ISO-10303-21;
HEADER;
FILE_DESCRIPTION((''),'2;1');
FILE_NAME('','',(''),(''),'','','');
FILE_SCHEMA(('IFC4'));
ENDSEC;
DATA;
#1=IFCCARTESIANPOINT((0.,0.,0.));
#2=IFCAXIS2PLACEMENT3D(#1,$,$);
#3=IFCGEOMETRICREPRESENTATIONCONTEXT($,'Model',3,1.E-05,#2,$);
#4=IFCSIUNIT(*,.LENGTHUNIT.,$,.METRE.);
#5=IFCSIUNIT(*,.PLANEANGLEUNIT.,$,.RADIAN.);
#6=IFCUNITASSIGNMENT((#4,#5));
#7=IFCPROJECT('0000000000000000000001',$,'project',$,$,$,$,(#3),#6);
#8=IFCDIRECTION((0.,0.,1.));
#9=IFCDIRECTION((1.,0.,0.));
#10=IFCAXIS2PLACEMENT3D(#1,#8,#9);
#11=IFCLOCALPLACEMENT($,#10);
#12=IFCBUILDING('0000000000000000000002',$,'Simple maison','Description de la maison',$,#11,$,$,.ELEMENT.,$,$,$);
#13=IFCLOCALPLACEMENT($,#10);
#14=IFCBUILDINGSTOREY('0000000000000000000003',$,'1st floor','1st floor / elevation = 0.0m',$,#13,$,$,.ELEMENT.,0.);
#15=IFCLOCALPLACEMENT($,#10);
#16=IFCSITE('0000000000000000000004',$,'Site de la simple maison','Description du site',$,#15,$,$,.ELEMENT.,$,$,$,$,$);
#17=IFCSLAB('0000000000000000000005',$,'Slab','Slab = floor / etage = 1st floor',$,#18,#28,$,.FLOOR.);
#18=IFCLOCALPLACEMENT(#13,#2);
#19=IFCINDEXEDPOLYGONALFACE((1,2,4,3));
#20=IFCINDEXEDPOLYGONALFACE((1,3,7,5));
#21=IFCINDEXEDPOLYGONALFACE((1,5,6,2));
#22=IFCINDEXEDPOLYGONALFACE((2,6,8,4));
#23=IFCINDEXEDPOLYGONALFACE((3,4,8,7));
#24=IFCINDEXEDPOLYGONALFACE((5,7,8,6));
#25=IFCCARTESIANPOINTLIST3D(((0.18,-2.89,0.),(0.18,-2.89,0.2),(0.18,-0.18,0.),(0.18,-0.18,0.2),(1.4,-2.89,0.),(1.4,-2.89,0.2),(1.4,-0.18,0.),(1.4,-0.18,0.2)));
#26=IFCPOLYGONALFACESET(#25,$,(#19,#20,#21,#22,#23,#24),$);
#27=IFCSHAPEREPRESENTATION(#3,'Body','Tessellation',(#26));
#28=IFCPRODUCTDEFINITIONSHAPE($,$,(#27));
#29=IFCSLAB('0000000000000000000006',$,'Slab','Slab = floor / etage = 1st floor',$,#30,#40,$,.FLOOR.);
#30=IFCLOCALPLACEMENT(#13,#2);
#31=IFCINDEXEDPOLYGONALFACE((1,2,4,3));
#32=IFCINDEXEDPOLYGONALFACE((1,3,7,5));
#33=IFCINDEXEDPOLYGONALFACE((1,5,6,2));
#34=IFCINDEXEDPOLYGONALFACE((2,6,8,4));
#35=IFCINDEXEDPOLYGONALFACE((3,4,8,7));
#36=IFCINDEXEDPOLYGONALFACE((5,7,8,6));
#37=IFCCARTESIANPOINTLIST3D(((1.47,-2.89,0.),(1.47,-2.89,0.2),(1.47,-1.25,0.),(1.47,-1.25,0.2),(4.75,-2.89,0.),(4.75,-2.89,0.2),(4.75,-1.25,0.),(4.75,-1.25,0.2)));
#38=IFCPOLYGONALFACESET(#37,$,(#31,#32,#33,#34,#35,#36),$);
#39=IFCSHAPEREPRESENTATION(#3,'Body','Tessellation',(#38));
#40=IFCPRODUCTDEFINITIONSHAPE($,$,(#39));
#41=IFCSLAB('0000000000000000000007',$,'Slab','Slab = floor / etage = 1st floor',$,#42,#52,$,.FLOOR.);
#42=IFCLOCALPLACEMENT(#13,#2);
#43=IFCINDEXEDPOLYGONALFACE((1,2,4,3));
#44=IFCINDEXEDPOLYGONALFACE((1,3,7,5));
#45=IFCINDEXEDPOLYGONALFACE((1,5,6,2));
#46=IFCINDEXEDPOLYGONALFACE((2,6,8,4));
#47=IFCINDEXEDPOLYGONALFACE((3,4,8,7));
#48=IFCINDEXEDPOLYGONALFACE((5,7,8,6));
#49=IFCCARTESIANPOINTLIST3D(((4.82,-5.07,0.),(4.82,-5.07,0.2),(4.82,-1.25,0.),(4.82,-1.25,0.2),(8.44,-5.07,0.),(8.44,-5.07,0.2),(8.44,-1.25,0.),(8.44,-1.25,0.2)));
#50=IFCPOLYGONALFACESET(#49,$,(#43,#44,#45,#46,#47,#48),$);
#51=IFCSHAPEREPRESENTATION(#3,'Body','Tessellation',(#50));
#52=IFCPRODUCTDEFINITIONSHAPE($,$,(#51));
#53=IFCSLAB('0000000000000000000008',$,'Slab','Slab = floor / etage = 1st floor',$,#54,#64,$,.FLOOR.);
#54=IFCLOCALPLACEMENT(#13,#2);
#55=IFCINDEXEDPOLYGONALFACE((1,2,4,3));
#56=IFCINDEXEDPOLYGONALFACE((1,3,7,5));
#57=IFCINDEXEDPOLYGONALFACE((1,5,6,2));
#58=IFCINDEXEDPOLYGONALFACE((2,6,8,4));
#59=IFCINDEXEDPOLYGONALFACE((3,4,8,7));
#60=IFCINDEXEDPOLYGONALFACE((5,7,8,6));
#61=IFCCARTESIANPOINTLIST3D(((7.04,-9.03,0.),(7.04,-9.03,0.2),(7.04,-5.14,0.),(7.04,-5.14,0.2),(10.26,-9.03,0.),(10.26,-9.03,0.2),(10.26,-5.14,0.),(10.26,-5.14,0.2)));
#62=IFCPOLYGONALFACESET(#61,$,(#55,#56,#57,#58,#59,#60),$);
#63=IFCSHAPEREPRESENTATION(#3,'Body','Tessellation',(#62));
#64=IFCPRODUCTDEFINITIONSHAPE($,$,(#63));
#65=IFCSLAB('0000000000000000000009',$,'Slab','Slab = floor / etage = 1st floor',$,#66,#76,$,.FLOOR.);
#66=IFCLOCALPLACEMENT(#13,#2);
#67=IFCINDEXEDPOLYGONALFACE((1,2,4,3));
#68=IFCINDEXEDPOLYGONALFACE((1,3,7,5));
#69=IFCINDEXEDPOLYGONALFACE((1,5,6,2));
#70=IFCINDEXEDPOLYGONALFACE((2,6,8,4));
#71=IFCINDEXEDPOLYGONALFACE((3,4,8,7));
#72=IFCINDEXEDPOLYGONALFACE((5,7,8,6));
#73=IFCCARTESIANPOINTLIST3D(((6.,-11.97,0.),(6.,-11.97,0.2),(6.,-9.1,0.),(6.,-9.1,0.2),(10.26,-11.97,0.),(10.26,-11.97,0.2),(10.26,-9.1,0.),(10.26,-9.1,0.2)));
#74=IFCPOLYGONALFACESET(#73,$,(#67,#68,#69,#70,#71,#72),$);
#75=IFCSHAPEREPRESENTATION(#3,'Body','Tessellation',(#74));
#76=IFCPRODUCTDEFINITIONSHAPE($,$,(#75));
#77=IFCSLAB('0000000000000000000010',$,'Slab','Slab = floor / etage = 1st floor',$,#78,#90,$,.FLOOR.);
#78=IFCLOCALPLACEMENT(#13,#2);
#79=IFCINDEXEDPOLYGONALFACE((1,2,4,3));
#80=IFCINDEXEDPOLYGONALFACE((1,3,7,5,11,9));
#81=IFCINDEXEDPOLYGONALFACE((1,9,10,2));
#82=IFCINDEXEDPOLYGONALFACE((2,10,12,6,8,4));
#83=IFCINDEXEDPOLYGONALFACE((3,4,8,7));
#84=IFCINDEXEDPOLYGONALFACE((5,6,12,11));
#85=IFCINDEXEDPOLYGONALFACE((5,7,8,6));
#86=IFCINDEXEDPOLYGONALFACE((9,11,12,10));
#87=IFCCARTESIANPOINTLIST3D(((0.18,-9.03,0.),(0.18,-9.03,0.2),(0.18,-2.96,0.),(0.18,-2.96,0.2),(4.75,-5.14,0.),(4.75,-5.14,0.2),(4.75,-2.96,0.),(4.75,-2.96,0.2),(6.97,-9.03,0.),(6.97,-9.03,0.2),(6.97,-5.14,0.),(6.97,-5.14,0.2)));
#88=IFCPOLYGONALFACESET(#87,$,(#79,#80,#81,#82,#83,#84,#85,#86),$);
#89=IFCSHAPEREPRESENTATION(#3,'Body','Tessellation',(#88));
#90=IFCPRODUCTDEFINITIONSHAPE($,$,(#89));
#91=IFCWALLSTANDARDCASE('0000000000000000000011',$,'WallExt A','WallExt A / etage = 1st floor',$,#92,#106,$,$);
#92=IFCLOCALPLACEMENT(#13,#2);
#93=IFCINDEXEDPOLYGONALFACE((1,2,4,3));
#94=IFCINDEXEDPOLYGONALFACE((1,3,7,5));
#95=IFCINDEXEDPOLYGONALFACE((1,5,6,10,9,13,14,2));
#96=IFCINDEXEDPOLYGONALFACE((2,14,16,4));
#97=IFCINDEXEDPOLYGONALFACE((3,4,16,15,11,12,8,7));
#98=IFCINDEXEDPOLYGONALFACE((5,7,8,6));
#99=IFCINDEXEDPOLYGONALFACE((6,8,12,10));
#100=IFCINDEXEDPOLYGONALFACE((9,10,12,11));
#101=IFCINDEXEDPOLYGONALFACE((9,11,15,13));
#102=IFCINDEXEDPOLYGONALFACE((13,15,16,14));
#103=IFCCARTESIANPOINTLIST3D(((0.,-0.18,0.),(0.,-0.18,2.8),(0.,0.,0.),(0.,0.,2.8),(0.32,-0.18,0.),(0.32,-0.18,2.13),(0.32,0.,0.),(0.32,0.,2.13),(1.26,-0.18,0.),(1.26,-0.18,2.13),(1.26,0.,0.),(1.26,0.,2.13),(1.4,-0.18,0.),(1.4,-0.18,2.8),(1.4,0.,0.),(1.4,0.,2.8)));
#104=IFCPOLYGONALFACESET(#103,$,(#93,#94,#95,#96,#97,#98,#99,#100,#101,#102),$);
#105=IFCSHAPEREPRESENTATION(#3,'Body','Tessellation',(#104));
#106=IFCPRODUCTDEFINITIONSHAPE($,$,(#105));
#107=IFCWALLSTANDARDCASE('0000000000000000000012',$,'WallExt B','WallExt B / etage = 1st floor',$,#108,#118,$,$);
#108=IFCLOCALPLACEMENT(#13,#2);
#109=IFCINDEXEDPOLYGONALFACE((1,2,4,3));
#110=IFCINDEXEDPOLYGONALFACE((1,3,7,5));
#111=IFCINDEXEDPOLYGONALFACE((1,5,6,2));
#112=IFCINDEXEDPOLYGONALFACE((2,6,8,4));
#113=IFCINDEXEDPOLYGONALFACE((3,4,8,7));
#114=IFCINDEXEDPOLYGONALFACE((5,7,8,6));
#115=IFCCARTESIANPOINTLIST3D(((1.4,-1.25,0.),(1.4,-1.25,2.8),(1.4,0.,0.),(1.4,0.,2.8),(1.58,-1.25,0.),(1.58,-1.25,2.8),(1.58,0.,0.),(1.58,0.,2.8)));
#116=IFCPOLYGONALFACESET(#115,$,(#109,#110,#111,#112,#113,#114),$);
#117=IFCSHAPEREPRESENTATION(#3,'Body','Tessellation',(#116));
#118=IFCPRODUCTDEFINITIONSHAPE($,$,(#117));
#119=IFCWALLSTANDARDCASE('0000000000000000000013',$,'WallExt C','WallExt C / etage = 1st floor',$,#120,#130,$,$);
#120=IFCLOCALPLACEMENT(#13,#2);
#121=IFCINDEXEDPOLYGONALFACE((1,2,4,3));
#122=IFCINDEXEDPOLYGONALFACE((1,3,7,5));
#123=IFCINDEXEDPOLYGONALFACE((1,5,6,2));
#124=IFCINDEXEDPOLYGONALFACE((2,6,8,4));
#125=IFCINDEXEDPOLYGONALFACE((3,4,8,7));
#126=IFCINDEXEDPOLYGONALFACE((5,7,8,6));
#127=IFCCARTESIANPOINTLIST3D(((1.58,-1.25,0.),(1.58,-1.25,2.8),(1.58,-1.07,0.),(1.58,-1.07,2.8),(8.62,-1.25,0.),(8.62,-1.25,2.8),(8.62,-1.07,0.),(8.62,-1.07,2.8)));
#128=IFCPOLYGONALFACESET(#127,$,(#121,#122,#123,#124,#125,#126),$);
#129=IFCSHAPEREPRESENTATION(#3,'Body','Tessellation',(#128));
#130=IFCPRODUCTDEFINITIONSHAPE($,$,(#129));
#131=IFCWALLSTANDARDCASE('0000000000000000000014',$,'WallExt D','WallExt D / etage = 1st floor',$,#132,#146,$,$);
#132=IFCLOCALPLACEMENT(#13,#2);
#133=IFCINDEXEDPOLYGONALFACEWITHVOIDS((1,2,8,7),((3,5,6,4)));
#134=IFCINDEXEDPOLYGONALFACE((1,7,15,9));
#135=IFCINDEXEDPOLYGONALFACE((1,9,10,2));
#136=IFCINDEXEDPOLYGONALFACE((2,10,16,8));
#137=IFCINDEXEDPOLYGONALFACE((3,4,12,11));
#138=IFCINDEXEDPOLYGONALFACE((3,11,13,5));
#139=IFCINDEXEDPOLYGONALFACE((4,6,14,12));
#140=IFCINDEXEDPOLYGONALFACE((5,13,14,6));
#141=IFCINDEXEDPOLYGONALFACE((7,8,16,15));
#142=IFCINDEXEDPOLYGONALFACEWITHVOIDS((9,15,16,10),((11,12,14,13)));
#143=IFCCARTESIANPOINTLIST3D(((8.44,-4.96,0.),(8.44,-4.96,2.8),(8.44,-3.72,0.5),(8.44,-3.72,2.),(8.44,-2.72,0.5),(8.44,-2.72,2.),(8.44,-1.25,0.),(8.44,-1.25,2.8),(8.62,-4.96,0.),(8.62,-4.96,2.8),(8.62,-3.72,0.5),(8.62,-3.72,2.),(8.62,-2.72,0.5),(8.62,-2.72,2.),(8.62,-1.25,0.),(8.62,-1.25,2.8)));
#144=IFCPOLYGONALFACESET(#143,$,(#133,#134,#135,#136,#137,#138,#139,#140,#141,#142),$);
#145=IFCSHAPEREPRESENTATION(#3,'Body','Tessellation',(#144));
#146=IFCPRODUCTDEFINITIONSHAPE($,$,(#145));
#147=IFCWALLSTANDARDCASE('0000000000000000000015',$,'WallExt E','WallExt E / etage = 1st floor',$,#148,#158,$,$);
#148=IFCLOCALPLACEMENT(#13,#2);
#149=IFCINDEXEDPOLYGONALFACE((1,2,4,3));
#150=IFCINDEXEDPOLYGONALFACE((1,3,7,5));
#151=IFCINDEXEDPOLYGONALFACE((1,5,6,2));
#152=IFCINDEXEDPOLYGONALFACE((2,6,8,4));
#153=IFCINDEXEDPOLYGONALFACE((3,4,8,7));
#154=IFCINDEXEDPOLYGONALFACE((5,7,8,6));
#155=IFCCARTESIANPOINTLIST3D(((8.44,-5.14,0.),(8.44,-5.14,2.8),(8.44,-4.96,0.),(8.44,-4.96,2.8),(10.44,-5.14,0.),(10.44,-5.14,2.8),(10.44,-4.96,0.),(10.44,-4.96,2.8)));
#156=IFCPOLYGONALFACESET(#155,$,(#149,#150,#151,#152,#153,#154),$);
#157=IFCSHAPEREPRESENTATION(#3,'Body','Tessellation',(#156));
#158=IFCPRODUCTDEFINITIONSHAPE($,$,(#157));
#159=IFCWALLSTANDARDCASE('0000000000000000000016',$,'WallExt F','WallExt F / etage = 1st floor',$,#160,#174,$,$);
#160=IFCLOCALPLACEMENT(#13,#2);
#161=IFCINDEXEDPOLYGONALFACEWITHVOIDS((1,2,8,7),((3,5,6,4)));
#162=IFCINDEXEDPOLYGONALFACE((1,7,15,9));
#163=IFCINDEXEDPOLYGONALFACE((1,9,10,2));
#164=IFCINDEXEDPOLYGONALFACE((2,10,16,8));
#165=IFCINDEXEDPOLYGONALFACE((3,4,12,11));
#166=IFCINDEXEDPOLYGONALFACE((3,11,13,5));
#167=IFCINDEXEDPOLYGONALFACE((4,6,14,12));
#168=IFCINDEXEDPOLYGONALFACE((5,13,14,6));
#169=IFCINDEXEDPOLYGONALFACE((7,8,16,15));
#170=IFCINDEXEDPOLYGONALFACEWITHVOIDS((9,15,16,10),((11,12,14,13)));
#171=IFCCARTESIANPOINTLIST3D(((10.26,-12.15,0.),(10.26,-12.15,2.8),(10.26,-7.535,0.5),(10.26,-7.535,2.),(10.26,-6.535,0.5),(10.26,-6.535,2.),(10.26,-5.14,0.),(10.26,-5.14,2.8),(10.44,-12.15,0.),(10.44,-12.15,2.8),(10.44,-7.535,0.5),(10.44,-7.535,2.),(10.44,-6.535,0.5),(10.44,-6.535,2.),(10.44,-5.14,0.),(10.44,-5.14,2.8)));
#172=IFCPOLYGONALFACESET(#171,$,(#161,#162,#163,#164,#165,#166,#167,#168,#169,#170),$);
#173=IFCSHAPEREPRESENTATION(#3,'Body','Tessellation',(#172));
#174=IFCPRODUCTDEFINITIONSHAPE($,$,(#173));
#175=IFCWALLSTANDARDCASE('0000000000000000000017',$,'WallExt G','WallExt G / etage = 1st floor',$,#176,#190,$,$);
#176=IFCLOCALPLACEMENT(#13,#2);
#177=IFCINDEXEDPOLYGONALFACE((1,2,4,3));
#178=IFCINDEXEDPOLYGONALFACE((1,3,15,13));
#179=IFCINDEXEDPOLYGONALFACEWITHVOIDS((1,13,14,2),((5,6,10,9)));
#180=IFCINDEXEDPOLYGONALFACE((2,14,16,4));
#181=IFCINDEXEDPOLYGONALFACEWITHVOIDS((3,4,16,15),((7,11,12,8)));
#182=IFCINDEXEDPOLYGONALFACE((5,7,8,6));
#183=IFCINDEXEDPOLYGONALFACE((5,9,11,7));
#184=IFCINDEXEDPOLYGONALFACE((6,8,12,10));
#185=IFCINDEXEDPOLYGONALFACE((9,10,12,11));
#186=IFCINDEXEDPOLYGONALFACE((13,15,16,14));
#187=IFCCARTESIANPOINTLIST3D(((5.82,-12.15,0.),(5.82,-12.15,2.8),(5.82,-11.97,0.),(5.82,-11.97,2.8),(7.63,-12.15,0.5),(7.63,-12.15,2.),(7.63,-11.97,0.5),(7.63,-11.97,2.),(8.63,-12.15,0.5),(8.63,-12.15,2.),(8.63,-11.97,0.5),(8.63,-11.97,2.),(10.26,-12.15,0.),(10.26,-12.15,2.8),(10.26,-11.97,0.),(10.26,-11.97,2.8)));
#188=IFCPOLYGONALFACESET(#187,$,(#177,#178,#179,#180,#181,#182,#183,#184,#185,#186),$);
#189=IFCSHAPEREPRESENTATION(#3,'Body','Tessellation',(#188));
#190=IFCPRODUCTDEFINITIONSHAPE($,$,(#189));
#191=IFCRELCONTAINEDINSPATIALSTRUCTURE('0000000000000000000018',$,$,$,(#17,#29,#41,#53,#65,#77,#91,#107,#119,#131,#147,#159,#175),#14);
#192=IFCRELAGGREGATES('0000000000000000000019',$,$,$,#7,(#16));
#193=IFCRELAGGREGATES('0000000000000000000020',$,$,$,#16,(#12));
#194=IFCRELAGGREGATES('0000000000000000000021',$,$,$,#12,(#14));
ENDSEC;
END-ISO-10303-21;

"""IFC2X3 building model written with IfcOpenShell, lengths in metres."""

from ifc_helpers import new_model, si_unit, frame, origin, origin_with_axes, origin_2d_with_axis, place, context, project, spatial, polyline, rectangle, outline, extrude, element, save


model = new_model("IFC2X3")

# Units and contexts
model_context = context("Model", 3, precision=1e-05, world=origin())
ifc_project = project(units=[si_unit("LENGTHUNIT", "METRE"), si_unit("PLANEANGLEUNIT", "RADIAN")], contexts=[model_context])

# Site, building, storey
site_placement = place(None, origin_with_axes())
site = spatial("IfcSite", under=ifc_project, at=site_placement, Name="Site de la simple maison", Description="Description du site", CompositionType="ELEMENT")
building_placement = place(None, origin_with_axes())
building = spatial("IfcBuilding", under=site, at=building_placement, Name="Simple maison", Description="Description de la maison", CompositionType="ELEMENT")
storey_placement = place(None, origin_with_axes())
storey = spatial("IfcBuildingStorey", under=building, at=storey_placement, Name="1st floor", Description="1st floor / elevation = 0.0m", CompositionType="ELEMENT", Elevation=0.0)

# Slabs
slab_1_placement = place(storey_placement, origin_with_axes())
element("IfcSlab", 1, at=slab_1_placement, inside=storey, Name="Slab", Description="Slab = floor / etage = 1st floor", PredefinedType="FLOOR", context=model_context, shape_type="SweptSolid", body=[
    extrude(outline(polyline([(0.18, -0.18), (1.4, -0.18), (1.4, -2.89), (0.18, -2.89), (0.18, -0.18)])), origin(), (0.0, 0.0, 1.0), 0.2),
])
slab_2_placement = place(storey_placement, origin_with_axes())
element("IfcSlab", 2, at=slab_2_placement, inside=storey, Name="Slab", Description="Slab = floor / etage = 1st floor", PredefinedType="FLOOR", context=model_context, shape_type="SweptSolid", body=[
    extrude(outline(polyline([(1.47, -1.25), (4.75, -1.25), (4.75, -2.89), (1.47, -2.89), (1.47, -1.25)])), origin(), (0.0, 0.0, 1.0), 0.2),
])
slab_3_placement = place(storey_placement, origin_with_axes())
element("IfcSlab", 3, at=slab_3_placement, inside=storey, Name="Slab", Description="Slab = floor / etage = 1st floor", PredefinedType="FLOOR", context=model_context, shape_type="SweptSolid", body=[
    extrude(outline(polyline([(4.82, -1.25), (8.44, -1.25), (8.44, -5.07), (4.82, -5.07), (4.82, -1.25)])), origin(), (0.0, 0.0, 1.0), 0.2),
])
slab_4_placement = place(storey_placement, origin_with_axes())
element("IfcSlab", 4, at=slab_4_placement, inside=storey, Name="Slab", Description="Slab = floor / etage = 1st floor", PredefinedType="FLOOR", context=model_context, shape_type="SweptSolid", body=[
    extrude(outline(polyline([(7.04, -5.14), (10.26, -5.14), (10.26, -9.03), (7.04, -9.03), (7.04, -5.14)])), origin(), (0.0, 0.0, 1.0), 0.2),
])
slab_5_placement = place(storey_placement, origin_with_axes())
element("IfcSlab", 5, at=slab_5_placement, inside=storey, Name="Slab", Description="Slab = floor / etage = 1st floor", PredefinedType="FLOOR", context=model_context, shape_type="SweptSolid", body=[
    extrude(outline(polyline([(6.0, -9.1), (10.26, -9.1), (10.26, -11.97), (6.0, -11.97), (6.0, -9.1)])), origin(), (0.0, 0.0, 1.0), 0.2),
])
slab_6_placement = place(storey_placement, origin_with_axes())
element("IfcSlab", 6, at=slab_6_placement, inside=storey, Name="Slab", Description="Slab = floor / etage = 1st floor", PredefinedType="FLOOR", context=model_context, shape_type="SweptSolid", body=[
    extrude(outline(polyline([(0.18, -2.96), (4.75, -2.96), (4.75, -5.14), (6.97, -5.14), (6.97, -9.03), (0.18, -9.03), (0.18, -2.96)])), origin(), (0.0, 0.0, 1.0), 0.2),
])

# Wall, opening
wall_1_placement = place(storey_placement, frame((0.0, -0.09, 0.0), z_axis=(0.0, 0.0, 1.0), x_axis=(1.0, 0.0, 0.0)))
wall_1 = element("IfcWallStandardCase", 7, at=wall_1_placement, inside=storey, Name="WallExt A", Description="WallExt A / etage = 1st floor", context=model_context, shape_type="SweptSolid", body=[
    extrude(outline(polyline([(0.0, 0.09), (1.4, 0.09), (1.4, -0.09), (0.0, -0.09), (0.0, 0.09)])), origin(), (0.0, 0.0, 1.0), 2.8),
])
opening_1_placement = place(wall_1_placement, frame((0.32, -0.09, 0.0), z_axis=(0.0, 0.0, 1.0), x_axis=(1.0, 0.0, 0.0)))
element("IfcOpeningElement", 8, at=opening_1_placement, cuts=wall_1, context=model_context, shape_type="SweptSolid", body=[
    extrude(rectangle(XDim=2.13, YDim=0.94, at=origin_2d_with_axis()), frame((0.47, 0.0, 1.065), z_axis=(0.0, 1.0, 0.0), x_axis=(0.0, 0.0, 1.0)), (0.0, 0.0, 1.0), 0.18),
])

# Walls
wall_2_placement = place(storey_placement, frame((1.49, 0.0, 0.0), z_axis=(0.0, 0.0, 1.0), x_axis=(0.0, -1.0, 0.0)))
element("IfcWallStandardCase", 9, at=wall_2_placement, inside=storey, Name="WallExt B", Description="WallExt B / etage = 1st floor", context=model_context, shape_type="SweptSolid", body=[
    extrude(outline(polyline([(0.0, 0.09), (1.25, 0.09), (1.25, -0.09), (0.0, -0.09), (0.0, 0.09)])), origin(), (0.0, 0.0, 1.0), 2.8),
])
wall_3_placement = place(storey_placement, frame((1.58, -1.16, 0.0), z_axis=(0.0, 0.0, 1.0), x_axis=(1.0, 0.0, 0.0)))
element("IfcWallStandardCase", 10, at=wall_3_placement, inside=storey, Name="WallExt C", Description="WallExt C / etage = 1st floor", context=model_context, shape_type="SweptSolid", body=[
    extrude(outline(polyline([(0.0, 0.09), (7.04, 0.09), (7.04, -0.09), (0.0, -0.09), (0.0, 0.09)])), origin(), (0.0, 0.0, 1.0), 2.8),
])

# Wall, opening
wall_4_placement = place(storey_placement, frame((8.53, -1.25, 0.0), z_axis=(0.0, 0.0, 1.0), x_axis=(0.0, -1.0, 0.0)))
wall_4 = element("IfcWallStandardCase", 11, at=wall_4_placement, inside=storey, Name="WallExt D", Description="WallExt D / etage = 1st floor", context=model_context, shape_type="SweptSolid", body=[
    extrude(outline(polyline([(0.0, 0.09), (3.71, 0.09), (3.71, -0.09), (0.0, -0.09), (0.0, 0.09)])), origin(), (0.0, 0.0, 1.0), 2.8),
])
opening_2_placement = place(wall_4_placement, frame((1.47, -0.09, 0.5), z_axis=(0.0, 0.0, 1.0), x_axis=(1.0, 0.0, 0.0)))
element("IfcOpeningElement", 12, at=opening_2_placement, cuts=wall_4, context=model_context, shape_type="SweptSolid", body=[
    extrude(rectangle(XDim=1.5, YDim=1.0, at=origin_2d_with_axis()), frame((0.5, 0.0, 0.75), z_axis=(0.0, 1.0, 0.0), x_axis=(0.0, 0.0, 1.0)), (0.0, 0.0, 1.0), 0.18),
])

# Wall
wall_5_placement = place(storey_placement, frame((8.44, -5.05, 0.0), z_axis=(0.0, 0.0, 1.0), x_axis=(1.0, 0.0, 0.0)))
element("IfcWallStandardCase", 13, at=wall_5_placement, inside=storey, Name="WallExt E", Description="WallExt E / etage = 1st floor", context=model_context, shape_type="SweptSolid", body=[
    extrude(outline(polyline([(0.0, 0.09), (2.0, 0.09), (2.0, -0.09), (0.0, -0.09), (0.0, 0.09)])), origin(), (0.0, 0.0, 1.0), 2.8),
])

# Walls, openings
wall_6_placement = place(storey_placement, frame((10.35, -5.14, 0.0), z_axis=(0.0, 0.0, 1.0), x_axis=(0.0, -1.0, 0.0)))
wall_6 = element("IfcWallStandardCase", 14, at=wall_6_placement, inside=storey, Name="WallExt F", Description="WallExt F / etage = 1st floor", context=model_context, shape_type="SweptSolid", body=[
    extrude(outline(polyline([(0.0, 0.09), (7.01, 0.09), (7.01, -0.09), (0.0, -0.09), (0.0, 0.09)])), origin(), (0.0, 0.0, 1.0), 2.8),
])
opening_3_placement = place(wall_6_placement, frame((1.395, -0.09, 0.5), z_axis=(0.0, 0.0, 1.0), x_axis=(1.0, 0.0, 0.0)))
element("IfcOpeningElement", 15, at=opening_3_placement, cuts=wall_6, context=model_context, shape_type="SweptSolid", body=[
    extrude(rectangle(XDim=1.5, YDim=1.0, at=origin_2d_with_axis()), frame((0.5, 0.0, 0.75), z_axis=(0.0, 1.0, 0.0), x_axis=(0.0, 0.0, 1.0)), (0.0, 0.0, 1.0), 0.18),
])
wall_7_placement = place(storey_placement, frame((10.26, -12.06, 0.0), z_axis=(0.0, 0.0, 1.0), x_axis=(-1.0, 0.0, 0.0)))
wall_7 = element("IfcWallStandardCase", 16, at=wall_7_placement, inside=storey, Name="WallExt G", Description="WallExt G / etage = 1st floor", context=model_context, shape_type="SweptSolid", body=[
    extrude(outline(polyline([(0.0, 0.09), (4.44, 0.09), (4.44, -0.09), (0.0, -0.09), (0.0, 0.09)])), origin(), (0.0, 0.0, 1.0), 2.8),
])
opening_4_placement = place(wall_7_placement, frame((1.63, -0.09, 0.5), z_axis=(0.0, 0.0, 1.0), x_axis=(1.0, 0.0, 0.0)))
element("IfcOpeningElement", 17, at=opening_4_placement, cuts=wall_7, context=model_context, shape_type="SweptSolid", body=[
    extrude(rectangle(XDim=1.5, YDim=1.0, at=origin_2d_with_axis()), frame((0.5, 0.0, 0.75), z_axis=(0.0, 1.0, 0.0), x_axis=(0.0, 0.0, 1.0)), (0.0, 0.0, 1.0), 0.18),
])

save(model, "model.ifc")
